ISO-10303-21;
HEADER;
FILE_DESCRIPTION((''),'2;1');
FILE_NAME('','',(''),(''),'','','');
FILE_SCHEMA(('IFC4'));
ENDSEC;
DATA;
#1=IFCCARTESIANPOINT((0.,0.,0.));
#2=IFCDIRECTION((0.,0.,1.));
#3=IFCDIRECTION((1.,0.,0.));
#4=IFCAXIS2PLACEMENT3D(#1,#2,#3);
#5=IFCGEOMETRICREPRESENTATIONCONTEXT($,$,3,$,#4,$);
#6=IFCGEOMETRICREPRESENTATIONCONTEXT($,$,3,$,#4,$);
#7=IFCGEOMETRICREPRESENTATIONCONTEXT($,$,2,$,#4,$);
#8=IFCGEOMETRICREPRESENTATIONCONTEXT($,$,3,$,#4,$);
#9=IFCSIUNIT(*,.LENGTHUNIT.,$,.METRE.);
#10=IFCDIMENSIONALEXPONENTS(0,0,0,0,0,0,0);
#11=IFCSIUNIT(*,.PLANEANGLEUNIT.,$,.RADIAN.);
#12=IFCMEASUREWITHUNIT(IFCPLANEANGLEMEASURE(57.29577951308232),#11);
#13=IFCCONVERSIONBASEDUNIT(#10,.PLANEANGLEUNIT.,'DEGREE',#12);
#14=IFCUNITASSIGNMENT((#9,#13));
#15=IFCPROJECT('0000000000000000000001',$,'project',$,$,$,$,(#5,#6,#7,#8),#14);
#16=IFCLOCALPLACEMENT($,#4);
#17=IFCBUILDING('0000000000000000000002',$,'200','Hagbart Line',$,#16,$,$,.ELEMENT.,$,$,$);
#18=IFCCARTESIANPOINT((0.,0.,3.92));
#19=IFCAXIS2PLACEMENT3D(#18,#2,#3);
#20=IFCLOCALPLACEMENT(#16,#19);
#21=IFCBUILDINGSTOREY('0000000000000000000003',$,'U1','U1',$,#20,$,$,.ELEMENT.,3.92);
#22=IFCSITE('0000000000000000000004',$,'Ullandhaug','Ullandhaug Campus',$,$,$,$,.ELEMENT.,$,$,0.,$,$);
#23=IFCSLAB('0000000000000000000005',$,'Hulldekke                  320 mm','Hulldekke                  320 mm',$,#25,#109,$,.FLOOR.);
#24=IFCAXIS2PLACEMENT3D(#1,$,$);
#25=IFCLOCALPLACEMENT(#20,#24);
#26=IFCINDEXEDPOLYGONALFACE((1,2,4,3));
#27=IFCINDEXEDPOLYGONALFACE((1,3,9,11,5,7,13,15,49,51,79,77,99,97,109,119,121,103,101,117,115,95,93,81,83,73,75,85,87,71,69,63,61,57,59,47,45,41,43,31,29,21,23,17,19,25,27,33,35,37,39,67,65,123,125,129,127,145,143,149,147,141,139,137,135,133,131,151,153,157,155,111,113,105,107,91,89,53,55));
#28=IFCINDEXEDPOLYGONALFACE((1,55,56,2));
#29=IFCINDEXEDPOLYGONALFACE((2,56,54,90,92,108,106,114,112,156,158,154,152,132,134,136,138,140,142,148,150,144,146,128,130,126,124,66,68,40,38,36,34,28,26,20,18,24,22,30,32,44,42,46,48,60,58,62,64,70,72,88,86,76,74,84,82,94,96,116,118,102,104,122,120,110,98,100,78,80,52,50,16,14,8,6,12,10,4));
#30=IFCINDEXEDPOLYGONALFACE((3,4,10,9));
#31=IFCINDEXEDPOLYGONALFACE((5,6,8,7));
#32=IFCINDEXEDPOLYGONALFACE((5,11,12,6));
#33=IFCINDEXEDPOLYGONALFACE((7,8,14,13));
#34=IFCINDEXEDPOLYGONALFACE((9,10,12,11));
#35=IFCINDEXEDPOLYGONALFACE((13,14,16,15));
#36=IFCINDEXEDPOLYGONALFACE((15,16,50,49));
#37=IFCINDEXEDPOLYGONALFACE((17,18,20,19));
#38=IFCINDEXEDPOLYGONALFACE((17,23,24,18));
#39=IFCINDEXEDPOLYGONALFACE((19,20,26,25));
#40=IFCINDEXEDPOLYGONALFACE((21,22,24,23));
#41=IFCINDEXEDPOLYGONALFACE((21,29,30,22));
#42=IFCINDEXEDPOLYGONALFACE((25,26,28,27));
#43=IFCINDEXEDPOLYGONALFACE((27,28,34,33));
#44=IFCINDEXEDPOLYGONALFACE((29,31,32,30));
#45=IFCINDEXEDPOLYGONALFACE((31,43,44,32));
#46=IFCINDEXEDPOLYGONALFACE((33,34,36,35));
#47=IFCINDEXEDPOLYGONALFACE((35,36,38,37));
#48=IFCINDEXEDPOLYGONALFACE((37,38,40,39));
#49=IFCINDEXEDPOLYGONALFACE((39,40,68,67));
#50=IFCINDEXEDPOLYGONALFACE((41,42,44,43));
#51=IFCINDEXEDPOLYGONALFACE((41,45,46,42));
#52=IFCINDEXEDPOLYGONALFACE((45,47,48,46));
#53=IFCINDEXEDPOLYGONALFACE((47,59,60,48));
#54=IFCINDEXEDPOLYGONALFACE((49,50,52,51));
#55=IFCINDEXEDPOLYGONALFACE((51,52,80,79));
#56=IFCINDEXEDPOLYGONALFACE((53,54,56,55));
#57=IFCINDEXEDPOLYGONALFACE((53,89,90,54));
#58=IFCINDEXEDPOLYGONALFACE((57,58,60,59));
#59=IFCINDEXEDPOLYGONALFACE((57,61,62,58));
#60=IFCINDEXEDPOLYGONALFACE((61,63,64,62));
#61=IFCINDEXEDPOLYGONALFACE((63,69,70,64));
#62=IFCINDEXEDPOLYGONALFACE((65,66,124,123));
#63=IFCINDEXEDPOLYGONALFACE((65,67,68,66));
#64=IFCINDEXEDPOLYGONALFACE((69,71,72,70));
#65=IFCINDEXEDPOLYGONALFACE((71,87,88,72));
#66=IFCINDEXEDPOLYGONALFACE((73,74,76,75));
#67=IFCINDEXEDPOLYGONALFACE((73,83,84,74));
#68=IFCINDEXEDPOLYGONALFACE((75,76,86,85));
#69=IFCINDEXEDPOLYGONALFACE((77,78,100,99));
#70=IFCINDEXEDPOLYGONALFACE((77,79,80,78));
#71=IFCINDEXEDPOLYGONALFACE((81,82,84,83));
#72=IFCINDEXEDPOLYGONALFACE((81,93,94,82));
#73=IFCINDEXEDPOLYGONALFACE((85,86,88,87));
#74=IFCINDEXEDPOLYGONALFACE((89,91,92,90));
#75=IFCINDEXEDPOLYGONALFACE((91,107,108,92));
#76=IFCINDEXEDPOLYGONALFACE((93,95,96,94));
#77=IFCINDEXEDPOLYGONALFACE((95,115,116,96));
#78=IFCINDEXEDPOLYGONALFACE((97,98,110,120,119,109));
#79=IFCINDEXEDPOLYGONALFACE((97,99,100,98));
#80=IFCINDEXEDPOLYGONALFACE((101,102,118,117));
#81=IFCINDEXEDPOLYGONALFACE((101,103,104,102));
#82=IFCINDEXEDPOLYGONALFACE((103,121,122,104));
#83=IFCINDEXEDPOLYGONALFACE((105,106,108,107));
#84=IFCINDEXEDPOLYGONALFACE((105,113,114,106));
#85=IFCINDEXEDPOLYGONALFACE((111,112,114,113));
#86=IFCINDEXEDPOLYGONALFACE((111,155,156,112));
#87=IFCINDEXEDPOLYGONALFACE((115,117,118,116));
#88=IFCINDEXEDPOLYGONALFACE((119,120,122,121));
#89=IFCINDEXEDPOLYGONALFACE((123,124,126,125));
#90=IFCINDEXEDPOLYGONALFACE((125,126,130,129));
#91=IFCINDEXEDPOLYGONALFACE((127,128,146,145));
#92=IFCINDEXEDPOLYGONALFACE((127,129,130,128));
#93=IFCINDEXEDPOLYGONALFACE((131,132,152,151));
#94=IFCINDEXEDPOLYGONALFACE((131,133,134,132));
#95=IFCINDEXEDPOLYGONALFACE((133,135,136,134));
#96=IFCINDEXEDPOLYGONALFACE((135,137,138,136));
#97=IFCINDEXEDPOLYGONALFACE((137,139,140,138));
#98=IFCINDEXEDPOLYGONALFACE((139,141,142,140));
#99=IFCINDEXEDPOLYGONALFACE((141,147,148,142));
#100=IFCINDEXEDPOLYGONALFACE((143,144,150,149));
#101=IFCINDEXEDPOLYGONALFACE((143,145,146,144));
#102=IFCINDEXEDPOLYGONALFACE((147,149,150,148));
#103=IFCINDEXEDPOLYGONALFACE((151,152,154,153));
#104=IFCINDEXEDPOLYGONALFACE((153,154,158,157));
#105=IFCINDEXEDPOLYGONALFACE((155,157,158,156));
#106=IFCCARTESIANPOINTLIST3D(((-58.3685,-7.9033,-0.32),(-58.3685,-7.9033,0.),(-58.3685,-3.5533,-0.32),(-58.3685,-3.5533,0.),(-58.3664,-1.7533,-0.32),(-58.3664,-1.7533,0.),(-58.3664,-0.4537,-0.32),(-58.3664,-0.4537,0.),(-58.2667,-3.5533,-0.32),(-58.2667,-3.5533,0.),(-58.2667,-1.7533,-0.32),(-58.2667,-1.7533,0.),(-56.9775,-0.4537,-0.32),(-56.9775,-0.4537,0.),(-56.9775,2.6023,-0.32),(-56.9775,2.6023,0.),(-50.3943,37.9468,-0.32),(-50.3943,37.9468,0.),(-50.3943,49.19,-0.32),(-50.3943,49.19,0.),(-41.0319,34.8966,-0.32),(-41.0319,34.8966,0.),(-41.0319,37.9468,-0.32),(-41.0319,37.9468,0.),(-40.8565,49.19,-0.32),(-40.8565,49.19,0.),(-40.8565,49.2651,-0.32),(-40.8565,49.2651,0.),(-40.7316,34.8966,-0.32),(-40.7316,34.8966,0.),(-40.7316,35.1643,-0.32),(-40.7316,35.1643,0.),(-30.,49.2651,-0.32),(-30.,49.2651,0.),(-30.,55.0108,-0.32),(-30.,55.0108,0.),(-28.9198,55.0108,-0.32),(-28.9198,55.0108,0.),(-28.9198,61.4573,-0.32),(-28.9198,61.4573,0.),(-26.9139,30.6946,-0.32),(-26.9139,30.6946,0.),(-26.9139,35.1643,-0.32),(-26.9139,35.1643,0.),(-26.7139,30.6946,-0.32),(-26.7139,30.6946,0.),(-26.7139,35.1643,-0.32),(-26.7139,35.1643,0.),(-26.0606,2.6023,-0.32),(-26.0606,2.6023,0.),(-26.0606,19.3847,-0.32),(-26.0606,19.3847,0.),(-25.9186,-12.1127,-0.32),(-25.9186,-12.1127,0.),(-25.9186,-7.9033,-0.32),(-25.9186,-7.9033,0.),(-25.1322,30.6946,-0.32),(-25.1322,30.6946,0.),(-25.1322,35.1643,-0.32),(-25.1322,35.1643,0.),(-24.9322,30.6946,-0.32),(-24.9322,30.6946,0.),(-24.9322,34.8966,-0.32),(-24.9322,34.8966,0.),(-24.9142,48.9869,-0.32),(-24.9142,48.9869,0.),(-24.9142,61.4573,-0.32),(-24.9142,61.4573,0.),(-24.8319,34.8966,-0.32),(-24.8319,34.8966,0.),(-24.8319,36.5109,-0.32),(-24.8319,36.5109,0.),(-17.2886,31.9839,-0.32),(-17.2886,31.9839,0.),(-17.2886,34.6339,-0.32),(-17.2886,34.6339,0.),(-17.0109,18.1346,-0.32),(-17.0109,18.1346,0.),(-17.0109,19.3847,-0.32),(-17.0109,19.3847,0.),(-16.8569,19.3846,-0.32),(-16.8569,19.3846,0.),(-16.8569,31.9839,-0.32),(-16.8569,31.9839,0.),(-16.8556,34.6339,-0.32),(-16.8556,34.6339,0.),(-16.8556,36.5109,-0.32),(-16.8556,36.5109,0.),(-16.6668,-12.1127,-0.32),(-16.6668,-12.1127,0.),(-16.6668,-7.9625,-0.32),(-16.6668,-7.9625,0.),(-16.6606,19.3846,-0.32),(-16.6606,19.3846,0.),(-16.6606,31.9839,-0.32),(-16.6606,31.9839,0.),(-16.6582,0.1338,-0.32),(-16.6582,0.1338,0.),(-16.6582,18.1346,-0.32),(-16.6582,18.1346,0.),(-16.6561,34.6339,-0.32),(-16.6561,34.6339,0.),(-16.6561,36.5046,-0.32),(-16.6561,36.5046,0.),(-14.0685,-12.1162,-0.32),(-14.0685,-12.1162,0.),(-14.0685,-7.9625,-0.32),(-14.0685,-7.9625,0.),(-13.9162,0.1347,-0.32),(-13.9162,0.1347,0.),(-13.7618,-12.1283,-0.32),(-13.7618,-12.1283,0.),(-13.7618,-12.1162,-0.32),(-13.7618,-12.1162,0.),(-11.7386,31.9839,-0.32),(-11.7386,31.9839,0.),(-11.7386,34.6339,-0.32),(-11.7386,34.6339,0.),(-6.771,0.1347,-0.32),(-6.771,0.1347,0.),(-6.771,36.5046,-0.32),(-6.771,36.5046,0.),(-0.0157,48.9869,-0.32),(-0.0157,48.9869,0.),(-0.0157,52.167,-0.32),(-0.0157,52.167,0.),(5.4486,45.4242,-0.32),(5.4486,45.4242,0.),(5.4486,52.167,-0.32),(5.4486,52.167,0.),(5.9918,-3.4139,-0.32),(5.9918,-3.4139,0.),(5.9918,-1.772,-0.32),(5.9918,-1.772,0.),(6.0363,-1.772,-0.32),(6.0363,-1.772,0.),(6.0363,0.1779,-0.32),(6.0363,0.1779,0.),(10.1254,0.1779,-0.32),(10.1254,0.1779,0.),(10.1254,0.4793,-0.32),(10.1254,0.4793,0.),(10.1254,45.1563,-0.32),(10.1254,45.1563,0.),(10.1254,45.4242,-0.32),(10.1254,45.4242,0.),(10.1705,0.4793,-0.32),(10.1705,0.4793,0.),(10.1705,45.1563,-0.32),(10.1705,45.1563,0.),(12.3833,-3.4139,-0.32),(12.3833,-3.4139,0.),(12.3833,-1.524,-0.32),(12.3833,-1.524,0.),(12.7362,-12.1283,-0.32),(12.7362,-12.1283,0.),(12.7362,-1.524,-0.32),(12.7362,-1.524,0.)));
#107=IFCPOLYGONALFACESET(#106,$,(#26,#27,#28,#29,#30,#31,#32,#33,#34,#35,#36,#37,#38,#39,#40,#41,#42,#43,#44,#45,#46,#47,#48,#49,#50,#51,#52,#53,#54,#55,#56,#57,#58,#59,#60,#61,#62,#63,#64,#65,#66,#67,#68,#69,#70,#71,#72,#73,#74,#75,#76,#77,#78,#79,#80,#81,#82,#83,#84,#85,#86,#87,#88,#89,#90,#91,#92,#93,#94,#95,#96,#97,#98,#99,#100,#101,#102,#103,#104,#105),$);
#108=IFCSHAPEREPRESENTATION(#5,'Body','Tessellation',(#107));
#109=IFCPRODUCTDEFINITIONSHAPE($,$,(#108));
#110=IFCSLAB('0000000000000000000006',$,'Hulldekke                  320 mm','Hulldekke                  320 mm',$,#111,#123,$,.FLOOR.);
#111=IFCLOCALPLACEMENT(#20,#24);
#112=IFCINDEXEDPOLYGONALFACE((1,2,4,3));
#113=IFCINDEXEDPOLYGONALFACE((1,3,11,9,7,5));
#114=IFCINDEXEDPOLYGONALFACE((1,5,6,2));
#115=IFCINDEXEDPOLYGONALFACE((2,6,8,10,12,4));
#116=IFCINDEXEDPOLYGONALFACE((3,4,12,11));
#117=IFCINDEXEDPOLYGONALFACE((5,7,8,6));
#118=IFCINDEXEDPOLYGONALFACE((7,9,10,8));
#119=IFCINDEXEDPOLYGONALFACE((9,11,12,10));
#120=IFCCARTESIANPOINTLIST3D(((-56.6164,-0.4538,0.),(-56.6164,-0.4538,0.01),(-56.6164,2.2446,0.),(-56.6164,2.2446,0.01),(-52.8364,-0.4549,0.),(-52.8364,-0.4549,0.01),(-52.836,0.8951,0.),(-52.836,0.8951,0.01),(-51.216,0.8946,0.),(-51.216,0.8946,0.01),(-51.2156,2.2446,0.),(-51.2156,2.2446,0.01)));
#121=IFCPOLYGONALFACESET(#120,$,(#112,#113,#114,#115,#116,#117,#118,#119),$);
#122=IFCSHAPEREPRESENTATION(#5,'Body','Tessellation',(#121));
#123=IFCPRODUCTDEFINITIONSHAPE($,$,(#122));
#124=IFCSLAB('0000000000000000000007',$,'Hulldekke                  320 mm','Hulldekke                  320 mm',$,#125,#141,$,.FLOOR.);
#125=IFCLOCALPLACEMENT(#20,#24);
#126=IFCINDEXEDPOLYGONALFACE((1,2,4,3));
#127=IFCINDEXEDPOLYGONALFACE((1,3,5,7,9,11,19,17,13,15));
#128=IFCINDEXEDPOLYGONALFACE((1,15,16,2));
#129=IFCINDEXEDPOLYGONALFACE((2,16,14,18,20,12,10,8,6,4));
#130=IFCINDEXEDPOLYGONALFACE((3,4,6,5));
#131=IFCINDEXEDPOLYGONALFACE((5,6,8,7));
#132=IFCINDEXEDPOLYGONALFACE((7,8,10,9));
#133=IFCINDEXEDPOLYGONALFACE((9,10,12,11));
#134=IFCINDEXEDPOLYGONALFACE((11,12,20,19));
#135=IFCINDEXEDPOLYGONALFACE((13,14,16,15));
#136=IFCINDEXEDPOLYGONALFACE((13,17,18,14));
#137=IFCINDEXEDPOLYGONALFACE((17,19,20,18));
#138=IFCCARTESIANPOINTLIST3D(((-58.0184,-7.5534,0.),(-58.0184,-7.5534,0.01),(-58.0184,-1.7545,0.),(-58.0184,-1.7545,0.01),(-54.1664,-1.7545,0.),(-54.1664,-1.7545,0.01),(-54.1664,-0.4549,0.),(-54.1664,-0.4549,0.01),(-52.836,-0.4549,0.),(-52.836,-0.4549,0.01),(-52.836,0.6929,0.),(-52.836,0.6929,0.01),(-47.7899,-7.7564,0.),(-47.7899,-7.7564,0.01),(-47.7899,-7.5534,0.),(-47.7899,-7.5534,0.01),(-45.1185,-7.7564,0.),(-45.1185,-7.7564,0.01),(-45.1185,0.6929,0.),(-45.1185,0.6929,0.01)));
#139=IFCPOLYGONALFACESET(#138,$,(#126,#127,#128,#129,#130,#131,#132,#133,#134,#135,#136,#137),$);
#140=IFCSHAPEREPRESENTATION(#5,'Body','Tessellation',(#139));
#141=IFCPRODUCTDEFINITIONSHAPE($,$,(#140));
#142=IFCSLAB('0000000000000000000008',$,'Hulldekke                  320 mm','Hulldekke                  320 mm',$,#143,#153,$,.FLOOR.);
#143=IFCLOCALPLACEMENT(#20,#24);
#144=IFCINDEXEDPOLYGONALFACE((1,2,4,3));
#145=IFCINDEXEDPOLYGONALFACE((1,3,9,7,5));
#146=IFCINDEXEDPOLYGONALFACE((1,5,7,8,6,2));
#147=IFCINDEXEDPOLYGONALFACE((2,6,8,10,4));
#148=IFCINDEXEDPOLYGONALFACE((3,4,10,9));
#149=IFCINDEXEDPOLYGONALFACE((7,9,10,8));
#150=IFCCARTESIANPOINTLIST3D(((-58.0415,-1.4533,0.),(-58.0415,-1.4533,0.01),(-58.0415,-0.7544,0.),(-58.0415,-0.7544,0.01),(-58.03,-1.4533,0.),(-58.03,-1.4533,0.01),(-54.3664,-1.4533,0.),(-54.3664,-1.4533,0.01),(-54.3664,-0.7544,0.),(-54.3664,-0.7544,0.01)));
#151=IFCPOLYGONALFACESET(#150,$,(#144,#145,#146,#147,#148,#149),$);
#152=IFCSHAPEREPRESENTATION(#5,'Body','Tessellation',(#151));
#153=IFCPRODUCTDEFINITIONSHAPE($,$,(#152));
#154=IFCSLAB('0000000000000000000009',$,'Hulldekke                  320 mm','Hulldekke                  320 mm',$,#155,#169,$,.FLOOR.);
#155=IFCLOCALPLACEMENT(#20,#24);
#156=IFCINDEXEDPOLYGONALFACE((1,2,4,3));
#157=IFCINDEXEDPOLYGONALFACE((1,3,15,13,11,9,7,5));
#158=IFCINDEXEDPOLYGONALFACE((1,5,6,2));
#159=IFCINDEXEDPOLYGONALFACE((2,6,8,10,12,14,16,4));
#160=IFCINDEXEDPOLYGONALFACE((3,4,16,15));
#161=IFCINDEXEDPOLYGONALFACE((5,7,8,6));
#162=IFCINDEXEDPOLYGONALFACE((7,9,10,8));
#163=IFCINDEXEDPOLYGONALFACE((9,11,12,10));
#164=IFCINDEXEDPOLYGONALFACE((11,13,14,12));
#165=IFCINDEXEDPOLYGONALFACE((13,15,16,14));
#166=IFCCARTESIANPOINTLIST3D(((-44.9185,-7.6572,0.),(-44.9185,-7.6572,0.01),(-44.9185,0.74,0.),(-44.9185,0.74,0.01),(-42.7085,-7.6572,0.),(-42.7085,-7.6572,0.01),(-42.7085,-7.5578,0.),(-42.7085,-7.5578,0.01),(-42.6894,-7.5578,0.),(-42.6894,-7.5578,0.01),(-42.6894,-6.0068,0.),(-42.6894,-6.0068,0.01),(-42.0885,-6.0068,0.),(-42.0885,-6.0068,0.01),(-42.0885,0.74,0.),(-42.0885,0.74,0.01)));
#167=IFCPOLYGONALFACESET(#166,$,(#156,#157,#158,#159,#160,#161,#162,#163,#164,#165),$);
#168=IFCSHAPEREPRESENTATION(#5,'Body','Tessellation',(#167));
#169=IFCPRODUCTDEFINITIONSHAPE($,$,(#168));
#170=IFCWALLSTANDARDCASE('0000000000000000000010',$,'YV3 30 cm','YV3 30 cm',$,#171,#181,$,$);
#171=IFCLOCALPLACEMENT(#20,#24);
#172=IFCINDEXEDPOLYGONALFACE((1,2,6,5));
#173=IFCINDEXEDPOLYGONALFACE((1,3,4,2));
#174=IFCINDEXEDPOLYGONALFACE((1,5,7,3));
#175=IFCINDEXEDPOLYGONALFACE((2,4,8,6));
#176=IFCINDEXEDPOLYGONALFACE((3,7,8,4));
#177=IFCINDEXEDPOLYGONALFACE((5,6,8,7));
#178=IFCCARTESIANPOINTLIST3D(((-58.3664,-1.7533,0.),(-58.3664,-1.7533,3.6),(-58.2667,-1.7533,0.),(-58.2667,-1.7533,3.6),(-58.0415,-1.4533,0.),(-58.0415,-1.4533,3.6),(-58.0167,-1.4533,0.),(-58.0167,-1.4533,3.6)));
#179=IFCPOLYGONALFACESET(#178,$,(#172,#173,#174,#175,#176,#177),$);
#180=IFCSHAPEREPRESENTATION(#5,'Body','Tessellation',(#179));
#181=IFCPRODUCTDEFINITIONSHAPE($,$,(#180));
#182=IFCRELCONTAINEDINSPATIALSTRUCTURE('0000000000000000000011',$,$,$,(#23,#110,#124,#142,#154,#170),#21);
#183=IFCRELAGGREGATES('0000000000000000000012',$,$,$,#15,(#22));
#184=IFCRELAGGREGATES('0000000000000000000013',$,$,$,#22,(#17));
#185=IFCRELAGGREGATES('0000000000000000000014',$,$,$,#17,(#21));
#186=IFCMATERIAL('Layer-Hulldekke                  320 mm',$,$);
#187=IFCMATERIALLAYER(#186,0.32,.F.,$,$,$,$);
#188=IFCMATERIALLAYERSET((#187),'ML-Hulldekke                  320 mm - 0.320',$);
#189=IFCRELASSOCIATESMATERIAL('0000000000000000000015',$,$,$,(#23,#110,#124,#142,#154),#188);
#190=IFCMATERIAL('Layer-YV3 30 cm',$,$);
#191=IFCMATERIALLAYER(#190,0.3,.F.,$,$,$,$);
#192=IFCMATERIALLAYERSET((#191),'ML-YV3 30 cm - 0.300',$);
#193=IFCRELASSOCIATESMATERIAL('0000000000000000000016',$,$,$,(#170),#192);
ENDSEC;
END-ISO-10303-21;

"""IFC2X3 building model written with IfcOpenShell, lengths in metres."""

from ifc_helpers import new_model, entity, si_unit, converted_unit, frame, origin_with_axes, place, context, project, spatial, polyline, outline, extrude, material, layer, layer_set, layer_usage, element, save


model = new_model("IFC2X3")

# Units and contexts
context_of_model_1 = context(None, 3, world=origin_with_axes())
context_of_model_2 = context(None, 3, world=origin_with_axes())
context_of_model_3 = context(None, 2, world=origin_with_axes())
context_of_model_4 = context(None, 3, world=origin_with_axes())
ifc_project = project(units=[si_unit("LENGTHUNIT", "METRE"), converted_unit("PLANEANGLEUNIT", "DEGREE", entity("IfcPlaneAngleMeasure", 57.29577951308232), si_unit("PLANEANGLEUNIT", "RADIAN"), dimensions=[0, 0, 0, 0, 0, 0, 0])], contexts=[context_of_model_1, context_of_model_2, context_of_model_3, context_of_model_4])

# Site, building, storey
site = spatial("IfcSite", under=ifc_project, Name="Ullandhaug", Description="Ullandhaug Campus", CompositionType="ELEMENT", RefElevation=0.0)
building_placement = place(None, origin_with_axes())
building = spatial("IfcBuilding", under=site, at=building_placement, Name="200", Description="Hagbart Line", CompositionType="ELEMENT")
storey_placement = place(building_placement, frame((0.0, 0.0, 3.92), z_axis=(0.0, 0.0, 1.0), x_axis=(1.0, 0.0, 0.0)))
storey = spatial("IfcBuildingStorey", under=building, at=storey_placement, Name="U1", Description="U1", CompositionType="ELEMENT", Elevation=3.92)

# Slabs
ifc_material_1 = material(Name="Layer-Hulldekke                  320 mm")
ifc_layer_1 = layer(ifc_material_1, 0.32, ventilated=False)
ifc_layer_set_1 = layer_set([ifc_layer_1], Name="ML-Hulldekke                  320 mm - 0.320")
ifc_layer_usage_1 = layer_usage(ifc_layer_set_1, "AXIS2", "POSITIVE", 0.0)
slab_1_placement = place(storey_placement, frame((-58.3685, -7.9033, 0.0), z_axis=(0.0, 0.0, 1.0), x_axis=(1.0, 0.0, 0.0)))
element("IfcSlab", 1, at=slab_1_placement, inside=storey, material=ifc_layer_usage_1, Name="Hulldekke                  320 mm", Description="Hulldekke                  320 mm", PredefinedType="FLOOR", context=context_of_model_1, shape_type="SweptSolid", body=[
    extrude(outline(polyline([(0.0, 0.0), (32.45, 0.0), (32.45, 4.2095), (41.7018, 4.2095), (41.7018, 0.0593), (44.3, 0.0593), (44.3, 4.2129), (44.6068, 4.2129), (44.6068, 4.225), (71.1048, 4.225), (71.1048, -6.3793), (70.7519, -6.3793), (70.7519, -4.4894), (64.3603, -4.4894), (64.3603, -6.1312), (64.4048, -6.1312), (64.4048, -8.0812), (68.494, -8.0812), (68.494, -8.3826), (68.539, -8.3826), (68.539, -53.0596), (68.494, -53.0596), (68.494, -53.3275), (63.8171, -53.3275), (63.8171, -60.0702), (58.3528, -60.0702), (58.3528, -56.8901), (33.4543, -56.8901), (33.4543, -69.3605), (29.4487, -69.3605), (29.4487, -62.9141), (28.3685, -62.9141), (28.3685, -57.1683), (17.512, -57.1683), (17.512, -57.0933), (7.9742, -57.0933), (7.9742, -45.85), (17.3366, -45.85), (17.3366, -42.7999), (17.6369, -42.7999), (17.6369, -43.0676), (31.4546, -43.0676), (31.4546, -38.5979), (31.6546, -38.5979), (31.6546, -43.0676), (33.2363, -43.0676), (33.2363, -38.5979), (33.4363, -38.5979), (33.4363, -42.7999), (33.5366, -42.7999), (33.5366, -44.4142), (41.513, -44.4142), (41.513, -42.5372), (41.0799, -42.5372), (41.0799, -39.8872), (41.5116, -39.8872), (41.5116, -27.2879), (41.708, -27.2879), (41.708, -39.8872), (46.6299, -39.8872), (46.6299, -42.5372), (41.7125, -42.5372), (41.7125, -44.4079), (51.5976, -44.4079), (51.5976, -8.038), (44.4523, -8.038), (41.7104, -8.037), (41.7104, -26.0378), (41.3576, -26.0378), (41.3576, -27.2879), (32.308, -27.2879), (32.308, -10.5056), (1.3911, -10.5056), (1.3911, -7.4496), (0.0022, -7.4496), (0.0022, -6.15), (0.1018, -6.15), (0.1018, -4.35), (0.0, -4.35), (0.0, 0.0)])), frame((0.0, 0.0, 0.0), z_axis=(0.0, 0.0, -1.0), x_axis=(1.0, 0.0, 0.0)), (0.0, 0.0, 1.0), 0.32),
])
slab_2_placement = place(storey_placement, frame((-56.6164, -0.4538, 0.0), z_axis=(0.0, 0.0, 1.0), x_axis=(1.0, 0.0, 0.0)))
element("IfcSlab", 2, at=slab_2_placement, inside=storey, material=ifc_layer_usage_1, Name="Hulldekke                  320 mm", Description="Hulldekke                  320 mm", PredefinedType="FLOOR", context=context_of_model_1, shape_type="SweptSolid", body=[
    extrude(outline(polyline([(0.0, 0.0), (3.78, 0.0), (3.78, 1.35), (5.4, 1.35), (5.4, 2.7), (-0.0008, 2.6984), (0.0, 0.0)])), frame((0.0, 0.0, 0.0), z_axis=(0.0, 0.0, 1.0), x_axis=(1.0, -0.000292, 0.0)), (0.0, 0.0, 1.0), 0.01),
])
slab_3_placement = place(storey_placement, frame((-58.0184, -7.5534, 0.0), z_axis=(0.0, 0.0, 1.0), x_axis=(1.0, 0.0, 0.0)))
element("IfcSlab", 3, at=slab_3_placement, inside=storey, material=ifc_layer_usage_1, Name="Hulldekke                  320 mm", Description="Hulldekke                  320 mm", PredefinedType="FLOOR", context=context_of_model_1, shape_type="SweptSolid", body=[
    extrude(outline(polyline([(0.0, 0.0), (10.2286, 0.0), (10.2286, 0.203), (12.9, 0.203), (12.9, -8.2462), (5.1824, -8.2462), (5.1824, -7.0985), (3.852, -7.0985), (3.852, -5.7989), (0.0, -5.7989), (0.0, 0.0)])), frame((0.0, 0.0, 0.0), z_axis=(0.0, 0.0, -1.0), x_axis=(1.0, 0.0, 0.0)), (0.0, 0.0, -1.0), 0.01),
])
slab_4_placement = place(storey_placement, frame((-58.03, -1.4533, 0.0), z_axis=(0.0, 0.0, 1.0), x_axis=(1.0, 0.0, 0.0)))
element("IfcSlab", 4, at=slab_4_placement, inside=storey, material=ifc_layer_usage_1, Name="Hulldekke                  320 mm", Description="Hulldekke                  320 mm", PredefinedType="FLOOR", context=context_of_model_1, shape_type="SweptSolid", body=[
    extrude(outline(polyline([(0.0, 0.0), (3.6636, 0.0), (3.6636, 0.6988), (-0.0116, 0.6988), (-0.0116, 0.0), (0.0, 0.0)])), origin_with_axes(), (0.0, 0.0, 1.0), 0.01),
])
slab_5_placement = place(storey_placement, frame((-44.9185, -7.6572, 0.0), z_axis=(0.0, 0.0, 1.0), x_axis=(1.0, 0.0, 0.0)))
element("IfcSlab", 5, at=slab_5_placement, inside=storey, material=ifc_layer_usage_1, Name="Hulldekke                  320 mm", Description="Hulldekke                  320 mm", PredefinedType="FLOOR", context=context_of_model_1, shape_type="SweptSolid", body=[
    extrude(outline(polyline([(0.0, 0.0), (2.21, 0.0), (2.21, 0.0994), (2.229, 0.0994), (2.229, 1.6503), (2.83, 1.6503), (2.83, 8.3972), (0.0, 8.3972), (0.0, 0.0)])), origin_with_axes(), (0.0, 0.0, 1.0), 0.01),
])

# Wall
ifc_material_2 = material(Name="Layer-YV3 30 cm")
ifc_layer_2 = layer(ifc_material_2, 0.3, ventilated=False)
ifc_layer_set_2 = layer_set([ifc_layer_2], Name="ML-YV3 30 cm - 0.300")
ifc_layer_usage_2 = layer_usage(ifc_layer_set_2, "AXIS2", "POSITIVE", 0.0)
wall_1_placement = place(storey_placement, frame((-58.3664, -1.7533, 0.0), z_axis=(0.0, 0.0, 1.0), x_axis=(1.0, 0.0, 0.0)))
element("IfcWallStandardCase", 6, at=wall_1_placement, inside=storey, material=ifc_layer_usage_2, Name="YV3 30 cm", Description="YV3 30 cm", context=context_of_model_1, shape_type="SweptSolid", body=[
    extrude(outline(polyline([(0.0, 0.0), (0.0996, 0.0), (0.3496, 0.3), (0.3248, 0.3), (0.0, 0.0)])), origin_with_axes(), (0.0, 0.0, 1.0), 3.6),
])

save(model, "model.ifc")
